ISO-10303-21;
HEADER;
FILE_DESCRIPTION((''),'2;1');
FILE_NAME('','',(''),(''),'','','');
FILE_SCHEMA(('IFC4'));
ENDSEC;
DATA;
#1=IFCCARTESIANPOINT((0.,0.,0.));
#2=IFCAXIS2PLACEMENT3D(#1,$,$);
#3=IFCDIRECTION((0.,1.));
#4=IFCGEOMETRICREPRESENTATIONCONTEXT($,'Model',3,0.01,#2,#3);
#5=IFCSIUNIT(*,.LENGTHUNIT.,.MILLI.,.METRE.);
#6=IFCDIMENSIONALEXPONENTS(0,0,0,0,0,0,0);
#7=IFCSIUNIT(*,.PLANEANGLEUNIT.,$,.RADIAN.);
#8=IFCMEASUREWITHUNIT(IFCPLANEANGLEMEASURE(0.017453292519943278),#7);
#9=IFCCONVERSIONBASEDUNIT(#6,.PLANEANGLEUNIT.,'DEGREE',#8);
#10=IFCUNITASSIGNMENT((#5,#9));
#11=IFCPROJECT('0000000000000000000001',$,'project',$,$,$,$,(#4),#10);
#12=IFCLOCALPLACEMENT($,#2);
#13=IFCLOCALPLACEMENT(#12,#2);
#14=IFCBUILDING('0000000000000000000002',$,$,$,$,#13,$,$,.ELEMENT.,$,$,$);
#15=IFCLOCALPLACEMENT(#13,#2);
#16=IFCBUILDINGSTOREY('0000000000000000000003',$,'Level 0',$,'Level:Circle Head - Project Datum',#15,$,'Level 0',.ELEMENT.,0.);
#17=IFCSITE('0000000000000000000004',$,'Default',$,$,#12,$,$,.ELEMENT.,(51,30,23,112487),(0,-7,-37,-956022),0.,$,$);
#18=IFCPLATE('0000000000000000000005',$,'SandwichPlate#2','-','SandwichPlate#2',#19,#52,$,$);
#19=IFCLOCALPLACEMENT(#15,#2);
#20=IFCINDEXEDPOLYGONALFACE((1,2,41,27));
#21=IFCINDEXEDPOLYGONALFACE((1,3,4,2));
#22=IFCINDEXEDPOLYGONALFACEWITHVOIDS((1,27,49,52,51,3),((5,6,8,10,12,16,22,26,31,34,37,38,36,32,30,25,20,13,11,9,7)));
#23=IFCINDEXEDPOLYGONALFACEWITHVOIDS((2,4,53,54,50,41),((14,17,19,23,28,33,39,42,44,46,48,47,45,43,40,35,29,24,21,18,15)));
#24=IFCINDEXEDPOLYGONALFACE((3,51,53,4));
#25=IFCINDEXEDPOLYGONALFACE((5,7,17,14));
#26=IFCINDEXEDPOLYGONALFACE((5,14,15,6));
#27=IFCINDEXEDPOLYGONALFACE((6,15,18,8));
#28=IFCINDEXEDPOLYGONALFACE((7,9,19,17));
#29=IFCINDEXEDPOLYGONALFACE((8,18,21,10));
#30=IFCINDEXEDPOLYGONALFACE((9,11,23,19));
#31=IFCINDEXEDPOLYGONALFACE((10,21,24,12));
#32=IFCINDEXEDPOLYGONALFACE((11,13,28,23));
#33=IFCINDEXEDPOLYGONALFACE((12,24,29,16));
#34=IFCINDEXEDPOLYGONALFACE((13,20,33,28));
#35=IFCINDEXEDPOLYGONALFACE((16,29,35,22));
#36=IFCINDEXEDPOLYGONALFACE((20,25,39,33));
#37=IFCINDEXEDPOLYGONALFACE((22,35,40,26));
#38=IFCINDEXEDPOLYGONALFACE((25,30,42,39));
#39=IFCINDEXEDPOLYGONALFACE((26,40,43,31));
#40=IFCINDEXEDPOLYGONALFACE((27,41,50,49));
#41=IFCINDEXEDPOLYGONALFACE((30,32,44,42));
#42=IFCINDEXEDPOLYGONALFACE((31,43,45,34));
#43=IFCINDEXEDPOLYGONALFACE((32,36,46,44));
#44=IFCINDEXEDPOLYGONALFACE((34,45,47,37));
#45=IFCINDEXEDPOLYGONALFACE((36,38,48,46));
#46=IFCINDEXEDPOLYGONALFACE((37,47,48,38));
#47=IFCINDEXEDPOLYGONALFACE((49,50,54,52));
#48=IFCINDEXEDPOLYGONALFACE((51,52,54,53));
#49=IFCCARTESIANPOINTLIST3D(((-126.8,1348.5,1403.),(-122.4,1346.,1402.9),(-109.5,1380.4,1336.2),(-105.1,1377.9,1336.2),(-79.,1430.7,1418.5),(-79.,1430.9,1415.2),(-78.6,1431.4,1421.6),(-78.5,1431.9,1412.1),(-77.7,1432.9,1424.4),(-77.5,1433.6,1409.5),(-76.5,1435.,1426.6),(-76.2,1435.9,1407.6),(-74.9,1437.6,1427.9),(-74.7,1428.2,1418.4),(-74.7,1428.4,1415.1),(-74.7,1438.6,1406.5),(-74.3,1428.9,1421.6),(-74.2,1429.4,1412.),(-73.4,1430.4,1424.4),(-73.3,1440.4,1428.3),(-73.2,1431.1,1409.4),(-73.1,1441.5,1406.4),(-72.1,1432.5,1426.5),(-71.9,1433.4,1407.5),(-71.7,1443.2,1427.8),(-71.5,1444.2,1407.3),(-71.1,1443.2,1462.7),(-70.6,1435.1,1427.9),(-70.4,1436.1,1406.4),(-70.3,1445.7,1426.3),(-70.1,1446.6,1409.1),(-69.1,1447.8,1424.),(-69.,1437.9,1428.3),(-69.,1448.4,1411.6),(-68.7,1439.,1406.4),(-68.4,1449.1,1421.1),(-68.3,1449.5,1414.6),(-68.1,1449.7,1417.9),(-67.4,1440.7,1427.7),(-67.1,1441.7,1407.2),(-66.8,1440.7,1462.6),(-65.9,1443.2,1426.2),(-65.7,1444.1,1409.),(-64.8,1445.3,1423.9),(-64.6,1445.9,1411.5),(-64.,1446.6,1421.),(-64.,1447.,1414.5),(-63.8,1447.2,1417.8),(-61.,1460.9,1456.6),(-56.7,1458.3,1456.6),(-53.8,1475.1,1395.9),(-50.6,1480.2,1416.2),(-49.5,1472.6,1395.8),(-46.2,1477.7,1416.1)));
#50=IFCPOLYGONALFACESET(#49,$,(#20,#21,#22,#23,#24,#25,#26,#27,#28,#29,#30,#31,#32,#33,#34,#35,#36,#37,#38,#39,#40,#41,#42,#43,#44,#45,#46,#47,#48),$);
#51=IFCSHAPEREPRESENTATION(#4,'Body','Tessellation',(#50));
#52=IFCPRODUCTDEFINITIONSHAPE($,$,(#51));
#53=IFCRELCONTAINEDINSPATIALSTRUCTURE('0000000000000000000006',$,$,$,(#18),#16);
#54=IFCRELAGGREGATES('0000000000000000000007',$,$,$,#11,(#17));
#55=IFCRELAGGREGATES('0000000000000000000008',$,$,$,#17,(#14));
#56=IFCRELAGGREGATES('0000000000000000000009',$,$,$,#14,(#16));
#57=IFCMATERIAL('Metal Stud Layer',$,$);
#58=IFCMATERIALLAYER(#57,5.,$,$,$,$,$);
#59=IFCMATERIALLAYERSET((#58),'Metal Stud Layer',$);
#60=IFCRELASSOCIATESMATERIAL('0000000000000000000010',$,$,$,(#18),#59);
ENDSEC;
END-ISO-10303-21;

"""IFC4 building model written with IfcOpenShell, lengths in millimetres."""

from ifc_helpers import new_model, entity, si_unit, converted_unit, direction, frame, origin, origin_with_axes, origin_2d_with_axis, place, context, project, spatial, polyline, circle, outline, extrude, material, layer, layer_set, element, save


model = new_model("IFC4")

# Units and contexts
model_context = context("Model", 3, precision=0.01, world=origin(), true_north=direction((0.0, 1.0)))
ifc_project = project(units=[si_unit("LENGTHUNIT", "METRE", prefix="MILLI"), converted_unit("PLANEANGLEUNIT", "DEGREE", entity("IfcPlaneAngleMeasure", 0.017453292519943278), si_unit("PLANEANGLEUNIT", "RADIAN"), dimensions=[0, 0, 0, 0, 0, 0, 0])], contexts=[model_context])

# Site, building, storey
site_placement = place(None, origin())
site = spatial("IfcSite", under=ifc_project, at=site_placement, Name="Default", CompositionType="ELEMENT", RefLatitude=(51, 30, 23, 112487), RefLongitude=(0, -7, -37, -956022), RefElevation=0.0)
building_placement = place(site_placement, origin())
building = spatial("IfcBuilding", under=site, at=building_placement, CompositionType="ELEMENT")
storey_placement = place(building_placement, origin())
storey = spatial("IfcBuildingStorey", under=building, at=storey_placement, Name="Level 0", ObjectType="Level:Circle Head - Project Datum", LongName="Level 0", CompositionType="ELEMENT", Elevation=0.0)

# Shared definitions
ifc_material_1 = material(Name="Metal Stud Layer")
ifc_layer_1 = layer(ifc_material_1, 5.0)
ifc_layer_set_1 = layer_set([ifc_layer_1], Name="Metal Stud Layer")

# Plate, openings
plate_1_placement = place(storey_placement, frame((-47.1, 1486.5, 1403.0), z_axis=(0.865935, -0.499948, -0.014432), x_axis=(-0.22762, -0.419615, 0.878699)))
plate_1 = element("IfcPlate", 1, at=plate_1_placement, inside=storey, material=ifc_layer_set_1, Name="SandwichPlate#2", Description="-", ObjectType="SandwichPlate#2", context=model_context, shape_type="SweptSolid", body=[
    extrude(outline(polyline([(0.0, 0.0), (76.0, 0.0), (76.0, 140.0), (0.0, 140.0), (0.0, 0.0)])), origin_with_axes(), (0.0, 0.0, 1.0), 5.0),
])
opening_1_placement = place(plate_1_placement, frame((0.0, 0.0, 0.0), z_axis=(0.0, 0.0, 1.0), x_axis=(1.0, 0.0, 0.0)))
element("IfcOpeningElement", 2, at=opening_1_placement, cuts=plate_1, ObjectType="Opening", context=model_context, shape_type="SweptSolid", body=[
    extrude(outline(polyline([(0.0, 0.0), (15.0, 0.0), (0.0, 15.0), (0.0, 0.0)])), origin(), (0.0, 0.0, 1.0), 5.0),
])
opening_2_placement = place(plate_1_placement, frame((0.0, 0.0, 0.0), z_axis=(0.0, 0.0, 1.0), x_axis=(1.0, 0.0, 0.0)))
element("IfcOpeningElement", 3, at=opening_2_placement, cuts=plate_1, ObjectType="Opening", context=model_context, shape_type="SweptSolid", body=[
    extrude(outline(polyline([(76.0, 0.0), (76.0, 15.0), (61.0, 0.0), (76.0, 0.0)])), origin(), (0.0, 0.0, 1.0), 5.0),
])
opening_3_placement = place(plate_1_placement, frame((38.0, 40.0, -0.5), z_axis=(0.0, 0.0, 1.0), x_axis=(0.0, 1.0, 0.0)))
element("IfcOpeningElement", 4, at=opening_3_placement, cuts=plate_1, ObjectType="Opening", context=model_context, shape_type="SweptSolid", body=[
    extrude(circle(Radius=11.0, at=origin_2d_with_axis()), origin(), (0.0, 0.0, 1.0), 6.0),
])

save(model, "model.ifc")
